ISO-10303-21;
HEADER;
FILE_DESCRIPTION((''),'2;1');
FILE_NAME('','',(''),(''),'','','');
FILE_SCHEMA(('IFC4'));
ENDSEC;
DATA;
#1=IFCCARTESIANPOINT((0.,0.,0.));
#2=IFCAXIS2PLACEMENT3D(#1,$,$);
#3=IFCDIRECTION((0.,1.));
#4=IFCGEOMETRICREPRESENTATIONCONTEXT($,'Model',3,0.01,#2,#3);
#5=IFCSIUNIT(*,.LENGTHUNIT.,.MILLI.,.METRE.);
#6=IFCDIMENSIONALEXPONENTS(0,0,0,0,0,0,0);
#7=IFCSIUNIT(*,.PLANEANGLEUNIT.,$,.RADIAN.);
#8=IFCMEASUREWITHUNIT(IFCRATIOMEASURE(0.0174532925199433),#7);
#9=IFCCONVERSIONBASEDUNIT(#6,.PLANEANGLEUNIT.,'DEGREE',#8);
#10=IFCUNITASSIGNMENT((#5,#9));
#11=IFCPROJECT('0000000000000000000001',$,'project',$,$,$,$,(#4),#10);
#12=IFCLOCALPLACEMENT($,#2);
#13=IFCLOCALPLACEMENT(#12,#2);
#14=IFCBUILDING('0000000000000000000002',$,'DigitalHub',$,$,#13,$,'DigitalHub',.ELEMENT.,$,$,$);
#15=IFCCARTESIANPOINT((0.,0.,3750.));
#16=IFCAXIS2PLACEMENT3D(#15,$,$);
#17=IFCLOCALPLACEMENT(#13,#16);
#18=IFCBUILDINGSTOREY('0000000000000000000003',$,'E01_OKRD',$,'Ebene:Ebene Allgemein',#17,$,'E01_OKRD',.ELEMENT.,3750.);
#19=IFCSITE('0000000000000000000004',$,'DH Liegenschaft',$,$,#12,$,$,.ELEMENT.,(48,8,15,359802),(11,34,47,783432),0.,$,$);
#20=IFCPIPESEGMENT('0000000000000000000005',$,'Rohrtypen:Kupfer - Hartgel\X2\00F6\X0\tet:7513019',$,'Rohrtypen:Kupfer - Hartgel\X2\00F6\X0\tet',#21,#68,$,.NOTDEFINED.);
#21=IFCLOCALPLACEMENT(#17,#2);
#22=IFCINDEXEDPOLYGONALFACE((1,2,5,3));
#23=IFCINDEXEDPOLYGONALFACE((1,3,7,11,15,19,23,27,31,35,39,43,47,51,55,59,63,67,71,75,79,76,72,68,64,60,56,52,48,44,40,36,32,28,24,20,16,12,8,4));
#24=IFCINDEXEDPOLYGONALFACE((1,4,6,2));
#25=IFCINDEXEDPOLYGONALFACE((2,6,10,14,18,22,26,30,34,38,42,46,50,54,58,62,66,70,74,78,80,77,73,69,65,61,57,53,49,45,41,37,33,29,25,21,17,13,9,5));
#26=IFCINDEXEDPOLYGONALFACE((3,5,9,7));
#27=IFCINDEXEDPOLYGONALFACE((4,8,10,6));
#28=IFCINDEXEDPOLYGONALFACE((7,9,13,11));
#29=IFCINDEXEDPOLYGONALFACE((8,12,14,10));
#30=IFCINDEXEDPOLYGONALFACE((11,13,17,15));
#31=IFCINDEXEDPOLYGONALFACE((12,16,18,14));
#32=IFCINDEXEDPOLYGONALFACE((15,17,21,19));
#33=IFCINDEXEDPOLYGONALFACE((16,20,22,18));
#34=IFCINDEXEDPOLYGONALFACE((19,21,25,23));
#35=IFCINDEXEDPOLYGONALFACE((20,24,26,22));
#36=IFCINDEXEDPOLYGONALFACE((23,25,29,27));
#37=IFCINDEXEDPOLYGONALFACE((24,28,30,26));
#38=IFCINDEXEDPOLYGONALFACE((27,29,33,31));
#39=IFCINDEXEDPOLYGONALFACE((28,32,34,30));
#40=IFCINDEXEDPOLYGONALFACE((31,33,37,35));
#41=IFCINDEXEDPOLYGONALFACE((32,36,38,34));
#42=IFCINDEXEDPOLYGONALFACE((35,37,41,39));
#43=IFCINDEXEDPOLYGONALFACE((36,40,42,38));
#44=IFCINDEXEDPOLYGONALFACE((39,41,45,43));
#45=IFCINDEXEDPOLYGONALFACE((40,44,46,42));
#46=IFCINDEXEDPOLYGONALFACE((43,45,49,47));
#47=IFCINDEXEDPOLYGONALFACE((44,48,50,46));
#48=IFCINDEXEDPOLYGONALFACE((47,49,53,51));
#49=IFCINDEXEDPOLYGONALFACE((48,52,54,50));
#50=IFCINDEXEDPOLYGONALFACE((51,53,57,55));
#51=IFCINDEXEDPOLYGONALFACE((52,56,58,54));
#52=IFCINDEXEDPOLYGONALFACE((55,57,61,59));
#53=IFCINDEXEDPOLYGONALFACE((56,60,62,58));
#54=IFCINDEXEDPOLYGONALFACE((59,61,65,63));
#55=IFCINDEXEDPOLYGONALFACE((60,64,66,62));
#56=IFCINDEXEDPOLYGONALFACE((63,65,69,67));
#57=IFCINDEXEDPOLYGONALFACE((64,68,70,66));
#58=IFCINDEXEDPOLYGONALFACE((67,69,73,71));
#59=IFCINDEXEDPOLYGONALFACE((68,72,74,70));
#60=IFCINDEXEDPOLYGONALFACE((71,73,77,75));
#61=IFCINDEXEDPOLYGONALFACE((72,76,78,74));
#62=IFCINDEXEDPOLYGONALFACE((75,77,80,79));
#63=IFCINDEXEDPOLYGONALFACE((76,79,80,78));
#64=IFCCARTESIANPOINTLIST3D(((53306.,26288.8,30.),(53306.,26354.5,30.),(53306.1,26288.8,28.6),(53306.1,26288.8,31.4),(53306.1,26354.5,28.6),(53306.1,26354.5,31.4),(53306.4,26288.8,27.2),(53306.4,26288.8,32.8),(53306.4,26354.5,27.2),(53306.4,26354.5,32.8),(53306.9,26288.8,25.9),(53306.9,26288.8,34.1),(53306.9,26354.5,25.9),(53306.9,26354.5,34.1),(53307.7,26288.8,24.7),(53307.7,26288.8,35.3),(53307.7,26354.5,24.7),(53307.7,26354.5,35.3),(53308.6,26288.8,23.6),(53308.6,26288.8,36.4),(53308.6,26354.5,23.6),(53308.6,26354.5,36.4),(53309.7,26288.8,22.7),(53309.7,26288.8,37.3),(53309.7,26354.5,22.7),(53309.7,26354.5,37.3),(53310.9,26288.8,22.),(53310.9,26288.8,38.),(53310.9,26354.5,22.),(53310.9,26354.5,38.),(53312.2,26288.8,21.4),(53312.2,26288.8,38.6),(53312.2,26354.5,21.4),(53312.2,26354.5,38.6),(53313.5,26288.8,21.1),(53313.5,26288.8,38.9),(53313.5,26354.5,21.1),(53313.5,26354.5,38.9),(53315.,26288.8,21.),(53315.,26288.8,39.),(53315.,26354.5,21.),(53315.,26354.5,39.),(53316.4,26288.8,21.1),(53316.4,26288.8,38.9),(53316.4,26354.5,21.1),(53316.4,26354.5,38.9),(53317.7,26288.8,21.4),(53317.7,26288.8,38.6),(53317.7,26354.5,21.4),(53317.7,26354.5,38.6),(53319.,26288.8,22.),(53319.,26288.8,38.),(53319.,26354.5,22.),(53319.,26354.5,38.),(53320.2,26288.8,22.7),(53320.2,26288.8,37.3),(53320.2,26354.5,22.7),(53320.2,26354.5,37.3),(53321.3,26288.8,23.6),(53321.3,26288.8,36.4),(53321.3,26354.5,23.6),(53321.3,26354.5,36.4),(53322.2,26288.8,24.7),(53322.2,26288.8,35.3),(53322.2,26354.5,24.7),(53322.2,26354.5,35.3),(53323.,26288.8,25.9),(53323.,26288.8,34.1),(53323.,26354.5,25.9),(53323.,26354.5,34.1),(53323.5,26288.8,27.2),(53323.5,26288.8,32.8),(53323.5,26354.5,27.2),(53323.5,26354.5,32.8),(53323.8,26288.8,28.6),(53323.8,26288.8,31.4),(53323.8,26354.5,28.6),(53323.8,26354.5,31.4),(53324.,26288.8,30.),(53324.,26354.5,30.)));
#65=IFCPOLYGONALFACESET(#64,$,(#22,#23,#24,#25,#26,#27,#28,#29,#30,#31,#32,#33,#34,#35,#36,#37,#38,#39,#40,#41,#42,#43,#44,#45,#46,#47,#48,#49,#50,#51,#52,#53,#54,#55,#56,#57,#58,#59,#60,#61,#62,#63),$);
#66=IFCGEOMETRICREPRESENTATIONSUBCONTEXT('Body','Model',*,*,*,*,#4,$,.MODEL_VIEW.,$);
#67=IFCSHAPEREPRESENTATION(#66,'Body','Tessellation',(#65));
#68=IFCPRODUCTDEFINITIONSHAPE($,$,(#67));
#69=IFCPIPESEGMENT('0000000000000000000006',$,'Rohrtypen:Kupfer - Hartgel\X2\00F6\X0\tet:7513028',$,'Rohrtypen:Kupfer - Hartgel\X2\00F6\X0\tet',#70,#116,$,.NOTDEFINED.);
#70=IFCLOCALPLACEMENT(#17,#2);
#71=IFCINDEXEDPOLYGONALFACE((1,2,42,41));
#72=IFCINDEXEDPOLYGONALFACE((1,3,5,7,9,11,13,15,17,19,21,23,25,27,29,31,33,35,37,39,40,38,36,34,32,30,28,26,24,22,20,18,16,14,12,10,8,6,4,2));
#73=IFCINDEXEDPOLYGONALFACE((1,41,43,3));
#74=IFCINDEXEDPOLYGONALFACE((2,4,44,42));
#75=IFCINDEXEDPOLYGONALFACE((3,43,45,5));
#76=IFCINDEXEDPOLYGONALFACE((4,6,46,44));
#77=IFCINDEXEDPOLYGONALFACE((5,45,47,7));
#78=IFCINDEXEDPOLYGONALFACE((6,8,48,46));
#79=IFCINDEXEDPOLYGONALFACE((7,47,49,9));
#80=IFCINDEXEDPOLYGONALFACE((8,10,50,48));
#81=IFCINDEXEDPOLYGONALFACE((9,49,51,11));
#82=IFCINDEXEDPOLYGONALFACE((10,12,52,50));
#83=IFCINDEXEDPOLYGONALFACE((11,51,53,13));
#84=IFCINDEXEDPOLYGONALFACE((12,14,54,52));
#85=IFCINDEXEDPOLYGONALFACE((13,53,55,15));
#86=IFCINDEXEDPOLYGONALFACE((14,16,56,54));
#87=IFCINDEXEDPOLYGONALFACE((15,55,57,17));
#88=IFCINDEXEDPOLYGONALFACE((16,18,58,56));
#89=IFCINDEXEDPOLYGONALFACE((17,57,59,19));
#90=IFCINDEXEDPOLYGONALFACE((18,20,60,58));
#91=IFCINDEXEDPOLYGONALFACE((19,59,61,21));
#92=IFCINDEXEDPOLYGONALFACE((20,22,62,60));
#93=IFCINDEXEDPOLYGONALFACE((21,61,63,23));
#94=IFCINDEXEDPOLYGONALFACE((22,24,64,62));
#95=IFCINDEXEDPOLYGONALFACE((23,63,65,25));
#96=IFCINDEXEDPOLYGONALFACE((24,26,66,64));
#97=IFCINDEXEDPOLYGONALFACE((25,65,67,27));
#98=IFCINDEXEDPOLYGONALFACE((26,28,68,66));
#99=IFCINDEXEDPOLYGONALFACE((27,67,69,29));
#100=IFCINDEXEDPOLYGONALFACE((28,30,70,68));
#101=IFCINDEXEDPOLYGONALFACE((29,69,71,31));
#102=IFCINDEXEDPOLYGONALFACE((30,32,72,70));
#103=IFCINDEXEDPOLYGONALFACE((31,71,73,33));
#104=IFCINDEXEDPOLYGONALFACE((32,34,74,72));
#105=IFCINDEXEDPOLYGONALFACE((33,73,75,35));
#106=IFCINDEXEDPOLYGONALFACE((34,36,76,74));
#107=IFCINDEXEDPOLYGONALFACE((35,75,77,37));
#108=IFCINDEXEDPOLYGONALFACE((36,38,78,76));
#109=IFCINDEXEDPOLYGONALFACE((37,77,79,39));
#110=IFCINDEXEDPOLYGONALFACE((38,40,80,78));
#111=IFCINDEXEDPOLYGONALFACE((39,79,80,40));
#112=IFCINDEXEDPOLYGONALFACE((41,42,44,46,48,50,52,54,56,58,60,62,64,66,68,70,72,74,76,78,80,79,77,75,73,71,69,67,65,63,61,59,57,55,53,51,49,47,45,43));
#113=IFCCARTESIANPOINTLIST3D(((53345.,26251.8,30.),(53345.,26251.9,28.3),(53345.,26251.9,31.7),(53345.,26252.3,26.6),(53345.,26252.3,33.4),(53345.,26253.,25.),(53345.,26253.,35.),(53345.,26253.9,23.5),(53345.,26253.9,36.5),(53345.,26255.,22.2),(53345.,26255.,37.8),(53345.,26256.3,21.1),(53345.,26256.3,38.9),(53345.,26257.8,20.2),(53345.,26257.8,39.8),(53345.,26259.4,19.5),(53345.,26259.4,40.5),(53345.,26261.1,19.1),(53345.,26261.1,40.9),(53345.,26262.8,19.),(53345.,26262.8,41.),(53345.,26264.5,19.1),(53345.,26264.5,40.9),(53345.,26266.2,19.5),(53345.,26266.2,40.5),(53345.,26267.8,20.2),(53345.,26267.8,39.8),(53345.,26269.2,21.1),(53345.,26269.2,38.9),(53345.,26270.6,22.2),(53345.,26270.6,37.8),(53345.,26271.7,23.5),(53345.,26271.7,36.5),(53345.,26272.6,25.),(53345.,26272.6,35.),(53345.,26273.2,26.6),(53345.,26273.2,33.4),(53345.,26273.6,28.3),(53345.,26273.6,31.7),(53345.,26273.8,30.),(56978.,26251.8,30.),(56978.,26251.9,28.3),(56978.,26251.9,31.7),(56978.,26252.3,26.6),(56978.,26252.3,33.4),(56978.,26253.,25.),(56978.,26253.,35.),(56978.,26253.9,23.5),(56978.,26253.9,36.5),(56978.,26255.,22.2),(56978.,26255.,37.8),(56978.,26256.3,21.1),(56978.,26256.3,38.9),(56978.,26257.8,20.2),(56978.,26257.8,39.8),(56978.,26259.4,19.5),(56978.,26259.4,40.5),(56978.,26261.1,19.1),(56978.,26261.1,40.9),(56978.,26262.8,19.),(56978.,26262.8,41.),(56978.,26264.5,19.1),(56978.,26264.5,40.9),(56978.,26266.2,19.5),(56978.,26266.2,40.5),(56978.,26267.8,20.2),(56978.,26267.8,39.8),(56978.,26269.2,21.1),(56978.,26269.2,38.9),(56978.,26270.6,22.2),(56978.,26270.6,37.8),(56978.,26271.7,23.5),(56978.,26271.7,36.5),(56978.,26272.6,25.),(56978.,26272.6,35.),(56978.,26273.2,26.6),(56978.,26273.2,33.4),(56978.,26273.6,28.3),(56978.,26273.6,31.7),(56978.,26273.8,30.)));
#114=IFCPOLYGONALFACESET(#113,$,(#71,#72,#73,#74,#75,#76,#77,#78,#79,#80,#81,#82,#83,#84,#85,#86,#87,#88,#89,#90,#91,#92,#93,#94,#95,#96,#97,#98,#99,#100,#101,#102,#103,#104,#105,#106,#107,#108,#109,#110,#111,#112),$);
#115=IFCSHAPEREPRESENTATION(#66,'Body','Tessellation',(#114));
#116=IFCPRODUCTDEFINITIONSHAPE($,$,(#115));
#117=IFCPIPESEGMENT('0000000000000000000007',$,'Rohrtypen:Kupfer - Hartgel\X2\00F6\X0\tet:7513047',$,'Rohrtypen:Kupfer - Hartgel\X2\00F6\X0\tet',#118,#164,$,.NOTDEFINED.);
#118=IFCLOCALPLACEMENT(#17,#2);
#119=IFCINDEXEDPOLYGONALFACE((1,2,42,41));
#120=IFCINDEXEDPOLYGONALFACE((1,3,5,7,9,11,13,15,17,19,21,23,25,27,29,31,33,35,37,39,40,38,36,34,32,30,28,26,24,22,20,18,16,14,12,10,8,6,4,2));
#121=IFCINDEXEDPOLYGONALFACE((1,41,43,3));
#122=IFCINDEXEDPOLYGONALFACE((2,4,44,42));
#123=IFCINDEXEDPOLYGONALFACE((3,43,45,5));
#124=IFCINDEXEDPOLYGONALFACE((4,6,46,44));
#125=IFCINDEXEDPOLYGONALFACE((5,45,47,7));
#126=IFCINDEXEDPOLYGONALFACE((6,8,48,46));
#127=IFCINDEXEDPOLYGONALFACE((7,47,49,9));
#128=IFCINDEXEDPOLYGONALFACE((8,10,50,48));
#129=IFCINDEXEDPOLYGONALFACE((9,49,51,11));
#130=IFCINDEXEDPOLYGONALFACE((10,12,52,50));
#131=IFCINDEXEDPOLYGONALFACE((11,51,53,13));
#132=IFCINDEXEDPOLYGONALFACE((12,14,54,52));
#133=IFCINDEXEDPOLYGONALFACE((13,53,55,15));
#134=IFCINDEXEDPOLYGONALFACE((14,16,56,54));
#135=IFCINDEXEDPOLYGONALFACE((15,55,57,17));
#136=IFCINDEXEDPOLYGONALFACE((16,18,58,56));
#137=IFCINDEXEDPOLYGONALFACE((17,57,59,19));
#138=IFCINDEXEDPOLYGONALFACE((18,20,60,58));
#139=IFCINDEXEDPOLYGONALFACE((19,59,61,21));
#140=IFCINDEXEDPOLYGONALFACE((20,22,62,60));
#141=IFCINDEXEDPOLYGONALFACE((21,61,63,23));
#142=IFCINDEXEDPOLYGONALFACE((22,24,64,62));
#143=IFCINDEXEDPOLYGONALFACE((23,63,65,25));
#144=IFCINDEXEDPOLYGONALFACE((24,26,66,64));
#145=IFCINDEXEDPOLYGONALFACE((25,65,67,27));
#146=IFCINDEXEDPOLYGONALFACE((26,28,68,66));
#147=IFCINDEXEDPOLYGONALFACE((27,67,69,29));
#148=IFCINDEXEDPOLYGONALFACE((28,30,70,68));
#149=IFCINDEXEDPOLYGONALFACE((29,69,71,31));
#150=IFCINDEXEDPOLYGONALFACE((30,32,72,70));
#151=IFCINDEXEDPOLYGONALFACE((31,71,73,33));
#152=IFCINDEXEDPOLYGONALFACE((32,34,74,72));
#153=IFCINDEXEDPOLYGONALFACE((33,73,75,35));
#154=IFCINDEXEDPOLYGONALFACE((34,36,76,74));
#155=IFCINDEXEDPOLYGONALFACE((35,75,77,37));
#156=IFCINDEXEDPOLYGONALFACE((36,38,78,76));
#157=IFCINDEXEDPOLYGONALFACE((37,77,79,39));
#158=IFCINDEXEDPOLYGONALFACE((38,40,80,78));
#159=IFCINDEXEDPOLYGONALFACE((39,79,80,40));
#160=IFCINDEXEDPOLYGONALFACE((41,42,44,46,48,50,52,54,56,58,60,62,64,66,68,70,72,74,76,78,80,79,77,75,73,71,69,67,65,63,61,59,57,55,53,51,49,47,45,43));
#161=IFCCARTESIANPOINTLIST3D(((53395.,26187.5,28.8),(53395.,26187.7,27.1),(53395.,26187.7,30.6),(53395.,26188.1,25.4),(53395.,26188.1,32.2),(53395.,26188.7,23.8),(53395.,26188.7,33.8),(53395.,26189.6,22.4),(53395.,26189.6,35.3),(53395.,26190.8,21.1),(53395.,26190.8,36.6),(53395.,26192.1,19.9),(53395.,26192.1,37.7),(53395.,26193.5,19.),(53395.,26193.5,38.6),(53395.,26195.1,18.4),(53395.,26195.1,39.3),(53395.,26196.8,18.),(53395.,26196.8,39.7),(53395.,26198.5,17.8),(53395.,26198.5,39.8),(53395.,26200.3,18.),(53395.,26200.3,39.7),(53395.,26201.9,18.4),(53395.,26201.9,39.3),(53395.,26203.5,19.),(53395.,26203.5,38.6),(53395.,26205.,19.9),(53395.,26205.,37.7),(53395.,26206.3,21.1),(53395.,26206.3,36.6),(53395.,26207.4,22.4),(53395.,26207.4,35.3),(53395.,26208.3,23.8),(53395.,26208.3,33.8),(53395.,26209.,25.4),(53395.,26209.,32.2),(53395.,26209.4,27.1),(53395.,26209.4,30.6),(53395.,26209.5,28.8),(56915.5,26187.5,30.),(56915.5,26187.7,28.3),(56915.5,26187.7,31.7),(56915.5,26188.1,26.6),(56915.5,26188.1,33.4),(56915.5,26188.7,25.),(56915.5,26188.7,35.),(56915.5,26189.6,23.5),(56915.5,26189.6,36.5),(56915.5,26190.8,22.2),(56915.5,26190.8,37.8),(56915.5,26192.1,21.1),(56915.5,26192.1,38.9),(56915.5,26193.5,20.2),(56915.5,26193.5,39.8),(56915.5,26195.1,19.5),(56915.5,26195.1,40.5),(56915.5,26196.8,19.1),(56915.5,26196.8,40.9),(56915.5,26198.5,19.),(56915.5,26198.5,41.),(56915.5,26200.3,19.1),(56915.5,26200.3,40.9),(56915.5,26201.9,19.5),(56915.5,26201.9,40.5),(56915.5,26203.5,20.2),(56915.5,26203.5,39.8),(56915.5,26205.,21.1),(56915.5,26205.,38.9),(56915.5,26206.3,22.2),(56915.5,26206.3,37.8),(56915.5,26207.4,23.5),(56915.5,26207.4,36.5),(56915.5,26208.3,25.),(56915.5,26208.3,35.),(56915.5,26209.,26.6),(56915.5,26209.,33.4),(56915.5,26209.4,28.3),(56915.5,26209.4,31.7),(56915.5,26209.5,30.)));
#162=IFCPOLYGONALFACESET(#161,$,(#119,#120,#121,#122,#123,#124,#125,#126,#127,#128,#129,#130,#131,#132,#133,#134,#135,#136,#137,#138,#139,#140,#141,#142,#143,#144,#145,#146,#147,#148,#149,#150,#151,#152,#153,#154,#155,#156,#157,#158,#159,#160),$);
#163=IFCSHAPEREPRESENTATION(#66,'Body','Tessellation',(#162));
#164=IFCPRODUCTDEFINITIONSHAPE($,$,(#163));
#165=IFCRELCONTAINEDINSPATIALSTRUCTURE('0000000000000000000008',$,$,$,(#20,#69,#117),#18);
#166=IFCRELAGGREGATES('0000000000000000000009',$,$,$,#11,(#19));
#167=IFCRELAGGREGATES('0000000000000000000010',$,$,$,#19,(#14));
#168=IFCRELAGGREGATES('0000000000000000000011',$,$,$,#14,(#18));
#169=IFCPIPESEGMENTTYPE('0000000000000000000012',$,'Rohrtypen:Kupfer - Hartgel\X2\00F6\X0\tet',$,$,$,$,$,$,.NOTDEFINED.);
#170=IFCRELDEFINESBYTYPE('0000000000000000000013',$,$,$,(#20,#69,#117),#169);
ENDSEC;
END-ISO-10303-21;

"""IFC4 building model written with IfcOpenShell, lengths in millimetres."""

from ifc_helpers import new_model, entity, si_unit, converted_unit, direction, frame, origin, place, context, subcontext, project, spatial, indexed_curve, outline, extrude, type_object, element, save


model = new_model("IFC4")

# Units and contexts
model_context = context("Model", 3, precision=0.01, world=origin(), true_north=direction((0.0, 1.0)))
body_context = subcontext(model_context, "Body", "Model", "MODEL_VIEW")
ifc_project = project(units=[si_unit("LENGTHUNIT", "METRE", prefix="MILLI"), converted_unit("PLANEANGLEUNIT", "DEGREE", entity("IfcRatioMeasure", 0.0174532925199433), si_unit("PLANEANGLEUNIT", "RADIAN"), dimensions=[0, 0, 0, 0, 0, 0, 0])], contexts=[model_context])

# Site, building, storey
site_placement = place(None, origin())
site = spatial("IfcSite", under=ifc_project, at=site_placement, Name="DH Liegenschaft", CompositionType="ELEMENT", RefLatitude=(48, 8, 15, 359802), RefLongitude=(11, 34, 47, 783432), RefElevation=0.0)
building_placement = place(site_placement, origin())
building = spatial("IfcBuilding", under=site, at=building_placement, Name="DigitalHub", LongName="DigitalHub", CompositionType="ELEMENT")
storey_placement = place(building_placement, frame((0.0, 0.0, 3750.0)))
storey = spatial("IfcBuildingStorey", under=building, at=storey_placement, Name="E01_OKRD", ObjectType="Ebene:Ebene Allgemein", LongName="E01_OKRD", CompositionType="ELEMENT", Elevation=3750.0)

# Pipe segments
pipe_segment_type = type_object("IfcPipeSegmentType", Name="Rohrtypen:Kupfer - Hartgelötet", PredefinedType="NOTDEFINED")
pipe_segment_1_placement = place(storey_placement, frame((53304.4, 26288.8, 19.4)))
element("IfcPipeSegment", 1, at=pipe_segment_1_placement, inside=storey, type_object=pipe_segment_type, Name="Rohrtypen:Kupfer - Hartgelötet:7513019", ObjectType="Rohrtypen:Kupfer - Hartgelötet", PredefinedType="NOTDEFINED", context=body_context, shape_type="SweptSolid", body=[
    extrude(outline(indexed_curve([(9.0, 0.0), (8.9, 1.4), (8.6, 2.8), (8.0, 4.1), (7.3, 5.3), (6.4, 6.4), (5.3, 7.3), (4.1, 8.0), (2.8, 8.6), (1.4, 8.9), (0.0, 9.0), (-1.4, 8.9), (-2.8, 8.6), (-4.1, 8.0), (-5.3, 7.3), (-6.4, 6.4), (-7.3, 5.3), (-8.0, 4.1), (-8.6, 2.8), (-8.9, 1.4), (-9.0, 0.0), (-8.9, -1.4), (-8.6, -2.8), (-8.0, -4.1), (-7.3, -5.3), (-6.4, -6.4), (-5.3, -7.3), (-4.1, -8.0), (-2.8, -8.6), (-1.4, -8.9), (0.0, -9.0), (1.4, -8.9), (2.8, -8.6), (4.1, -8.0), (5.3, -7.3), (6.4, -6.4), (7.3, -5.3), (8.0, -4.1), (8.6, -2.8), (8.9, -1.4), (9.0, 0.0)], self_intersect=False)), frame((10.6, 0.0, 10.6), z_axis=(0.0, 1.0, 0.0), x_axis=(1.0, 0.0, 0.0)), (0.0, 0.0, 1.0), 65.7),
])
pipe_segment_2_placement = place(storey_placement, frame((53345.0, 26250.2, 17.4)))
element("IfcPipeSegment", 2, at=pipe_segment_2_placement, inside=storey, type_object=pipe_segment_type, Name="Rohrtypen:Kupfer - Hartgelötet:7513028", ObjectType="Rohrtypen:Kupfer - Hartgelötet", PredefinedType="NOTDEFINED", context=body_context, shape_type="SweptSolid", body=[
    extrude(outline(indexed_curve([(11.0, 0.0), (10.9, 1.7), (10.5, 3.4), (9.8, 5.0), (8.9, 6.5), (7.8, 7.8), (6.5, 8.9), (5.0, 9.8), (3.4, 10.5), (1.7, 10.9), (0.0, 11.0), (-1.7, 10.9), (-3.4, 10.5), (-5.0, 9.8), (-6.5, 8.9), (-7.8, 7.8), (-8.9, 6.5), (-9.8, 5.0), (-10.5, 3.4), (-10.9, 1.7), (-11.0, 0.0), (-10.9, -1.7), (-10.5, -3.4), (-9.8, -5.0), (-8.9, -6.5), (-7.8, -7.8), (-6.5, -8.9), (-5.0, -9.8), (-3.4, -10.5), (-1.7, -10.9), (0.0, -11.0), (1.7, -10.9), (3.4, -10.5), (5.0, -9.8), (6.5, -8.9), (7.8, -7.8), (8.9, -6.5), (9.8, -5.0), (10.5, -3.4), (10.9, -1.7), (11.0, 0.0)], self_intersect=False)), frame((0.0, 12.6, 12.6), z_axis=(1.0, 0.0, 0.0), x_axis=(0.0, 1.0, 0.0)), (0.0, 0.0, 1.0), 3633.0),
])
pipe_segment_3_placement = place(storey_placement, frame((53395.0, 26185.9, 16.2)))
element("IfcPipeSegment", 3, at=pipe_segment_3_placement, inside=storey, type_object=pipe_segment_type, Name="Rohrtypen:Kupfer - Hartgelötet:7513047", ObjectType="Rohrtypen:Kupfer - Hartgelötet", PredefinedType="NOTDEFINED", context=body_context, shape_type="SweptSolid", body=[
    extrude(outline(indexed_curve([(11.0, 0.0), (10.9, 1.7), (10.5, 3.4), (9.8, 5.0), (8.9, 6.5), (7.8, 7.8), (6.5, 8.9), (5.0, 9.8), (3.4, 10.5), (1.7, 10.9), (0.0, 11.0), (-1.7, 10.9), (-3.4, 10.5), (-5.0, 9.8), (-6.5, 8.9), (-7.8, 7.8), (-8.9, 6.5), (-9.8, 5.0), (-10.5, 3.4), (-10.9, 1.7), (-11.0, 0.0), (-10.9, -1.7), (-10.5, -3.4), (-9.8, -5.0), (-8.9, -6.5), (-7.8, -7.8), (-6.5, -8.9), (-5.0, -9.8), (-3.4, -10.5), (-1.7, -10.9), (0.0, -11.0), (1.7, -10.9), (3.4, -10.5), (5.0, -9.8), (6.5, -8.9), (7.8, -7.8), (8.9, -6.5), (9.8, -5.0), (10.5, -3.4), (10.9, -1.7), (11.0, 0.0)], self_intersect=False)), frame((0.0, 12.6, 12.6), z_axis=(1.0, 0.0, 0.000331), x_axis=(0.0, 1.0, 0.0)), (0.0, 0.0, 1.0), 3520.5),
])

save(model, "model.ifc")
